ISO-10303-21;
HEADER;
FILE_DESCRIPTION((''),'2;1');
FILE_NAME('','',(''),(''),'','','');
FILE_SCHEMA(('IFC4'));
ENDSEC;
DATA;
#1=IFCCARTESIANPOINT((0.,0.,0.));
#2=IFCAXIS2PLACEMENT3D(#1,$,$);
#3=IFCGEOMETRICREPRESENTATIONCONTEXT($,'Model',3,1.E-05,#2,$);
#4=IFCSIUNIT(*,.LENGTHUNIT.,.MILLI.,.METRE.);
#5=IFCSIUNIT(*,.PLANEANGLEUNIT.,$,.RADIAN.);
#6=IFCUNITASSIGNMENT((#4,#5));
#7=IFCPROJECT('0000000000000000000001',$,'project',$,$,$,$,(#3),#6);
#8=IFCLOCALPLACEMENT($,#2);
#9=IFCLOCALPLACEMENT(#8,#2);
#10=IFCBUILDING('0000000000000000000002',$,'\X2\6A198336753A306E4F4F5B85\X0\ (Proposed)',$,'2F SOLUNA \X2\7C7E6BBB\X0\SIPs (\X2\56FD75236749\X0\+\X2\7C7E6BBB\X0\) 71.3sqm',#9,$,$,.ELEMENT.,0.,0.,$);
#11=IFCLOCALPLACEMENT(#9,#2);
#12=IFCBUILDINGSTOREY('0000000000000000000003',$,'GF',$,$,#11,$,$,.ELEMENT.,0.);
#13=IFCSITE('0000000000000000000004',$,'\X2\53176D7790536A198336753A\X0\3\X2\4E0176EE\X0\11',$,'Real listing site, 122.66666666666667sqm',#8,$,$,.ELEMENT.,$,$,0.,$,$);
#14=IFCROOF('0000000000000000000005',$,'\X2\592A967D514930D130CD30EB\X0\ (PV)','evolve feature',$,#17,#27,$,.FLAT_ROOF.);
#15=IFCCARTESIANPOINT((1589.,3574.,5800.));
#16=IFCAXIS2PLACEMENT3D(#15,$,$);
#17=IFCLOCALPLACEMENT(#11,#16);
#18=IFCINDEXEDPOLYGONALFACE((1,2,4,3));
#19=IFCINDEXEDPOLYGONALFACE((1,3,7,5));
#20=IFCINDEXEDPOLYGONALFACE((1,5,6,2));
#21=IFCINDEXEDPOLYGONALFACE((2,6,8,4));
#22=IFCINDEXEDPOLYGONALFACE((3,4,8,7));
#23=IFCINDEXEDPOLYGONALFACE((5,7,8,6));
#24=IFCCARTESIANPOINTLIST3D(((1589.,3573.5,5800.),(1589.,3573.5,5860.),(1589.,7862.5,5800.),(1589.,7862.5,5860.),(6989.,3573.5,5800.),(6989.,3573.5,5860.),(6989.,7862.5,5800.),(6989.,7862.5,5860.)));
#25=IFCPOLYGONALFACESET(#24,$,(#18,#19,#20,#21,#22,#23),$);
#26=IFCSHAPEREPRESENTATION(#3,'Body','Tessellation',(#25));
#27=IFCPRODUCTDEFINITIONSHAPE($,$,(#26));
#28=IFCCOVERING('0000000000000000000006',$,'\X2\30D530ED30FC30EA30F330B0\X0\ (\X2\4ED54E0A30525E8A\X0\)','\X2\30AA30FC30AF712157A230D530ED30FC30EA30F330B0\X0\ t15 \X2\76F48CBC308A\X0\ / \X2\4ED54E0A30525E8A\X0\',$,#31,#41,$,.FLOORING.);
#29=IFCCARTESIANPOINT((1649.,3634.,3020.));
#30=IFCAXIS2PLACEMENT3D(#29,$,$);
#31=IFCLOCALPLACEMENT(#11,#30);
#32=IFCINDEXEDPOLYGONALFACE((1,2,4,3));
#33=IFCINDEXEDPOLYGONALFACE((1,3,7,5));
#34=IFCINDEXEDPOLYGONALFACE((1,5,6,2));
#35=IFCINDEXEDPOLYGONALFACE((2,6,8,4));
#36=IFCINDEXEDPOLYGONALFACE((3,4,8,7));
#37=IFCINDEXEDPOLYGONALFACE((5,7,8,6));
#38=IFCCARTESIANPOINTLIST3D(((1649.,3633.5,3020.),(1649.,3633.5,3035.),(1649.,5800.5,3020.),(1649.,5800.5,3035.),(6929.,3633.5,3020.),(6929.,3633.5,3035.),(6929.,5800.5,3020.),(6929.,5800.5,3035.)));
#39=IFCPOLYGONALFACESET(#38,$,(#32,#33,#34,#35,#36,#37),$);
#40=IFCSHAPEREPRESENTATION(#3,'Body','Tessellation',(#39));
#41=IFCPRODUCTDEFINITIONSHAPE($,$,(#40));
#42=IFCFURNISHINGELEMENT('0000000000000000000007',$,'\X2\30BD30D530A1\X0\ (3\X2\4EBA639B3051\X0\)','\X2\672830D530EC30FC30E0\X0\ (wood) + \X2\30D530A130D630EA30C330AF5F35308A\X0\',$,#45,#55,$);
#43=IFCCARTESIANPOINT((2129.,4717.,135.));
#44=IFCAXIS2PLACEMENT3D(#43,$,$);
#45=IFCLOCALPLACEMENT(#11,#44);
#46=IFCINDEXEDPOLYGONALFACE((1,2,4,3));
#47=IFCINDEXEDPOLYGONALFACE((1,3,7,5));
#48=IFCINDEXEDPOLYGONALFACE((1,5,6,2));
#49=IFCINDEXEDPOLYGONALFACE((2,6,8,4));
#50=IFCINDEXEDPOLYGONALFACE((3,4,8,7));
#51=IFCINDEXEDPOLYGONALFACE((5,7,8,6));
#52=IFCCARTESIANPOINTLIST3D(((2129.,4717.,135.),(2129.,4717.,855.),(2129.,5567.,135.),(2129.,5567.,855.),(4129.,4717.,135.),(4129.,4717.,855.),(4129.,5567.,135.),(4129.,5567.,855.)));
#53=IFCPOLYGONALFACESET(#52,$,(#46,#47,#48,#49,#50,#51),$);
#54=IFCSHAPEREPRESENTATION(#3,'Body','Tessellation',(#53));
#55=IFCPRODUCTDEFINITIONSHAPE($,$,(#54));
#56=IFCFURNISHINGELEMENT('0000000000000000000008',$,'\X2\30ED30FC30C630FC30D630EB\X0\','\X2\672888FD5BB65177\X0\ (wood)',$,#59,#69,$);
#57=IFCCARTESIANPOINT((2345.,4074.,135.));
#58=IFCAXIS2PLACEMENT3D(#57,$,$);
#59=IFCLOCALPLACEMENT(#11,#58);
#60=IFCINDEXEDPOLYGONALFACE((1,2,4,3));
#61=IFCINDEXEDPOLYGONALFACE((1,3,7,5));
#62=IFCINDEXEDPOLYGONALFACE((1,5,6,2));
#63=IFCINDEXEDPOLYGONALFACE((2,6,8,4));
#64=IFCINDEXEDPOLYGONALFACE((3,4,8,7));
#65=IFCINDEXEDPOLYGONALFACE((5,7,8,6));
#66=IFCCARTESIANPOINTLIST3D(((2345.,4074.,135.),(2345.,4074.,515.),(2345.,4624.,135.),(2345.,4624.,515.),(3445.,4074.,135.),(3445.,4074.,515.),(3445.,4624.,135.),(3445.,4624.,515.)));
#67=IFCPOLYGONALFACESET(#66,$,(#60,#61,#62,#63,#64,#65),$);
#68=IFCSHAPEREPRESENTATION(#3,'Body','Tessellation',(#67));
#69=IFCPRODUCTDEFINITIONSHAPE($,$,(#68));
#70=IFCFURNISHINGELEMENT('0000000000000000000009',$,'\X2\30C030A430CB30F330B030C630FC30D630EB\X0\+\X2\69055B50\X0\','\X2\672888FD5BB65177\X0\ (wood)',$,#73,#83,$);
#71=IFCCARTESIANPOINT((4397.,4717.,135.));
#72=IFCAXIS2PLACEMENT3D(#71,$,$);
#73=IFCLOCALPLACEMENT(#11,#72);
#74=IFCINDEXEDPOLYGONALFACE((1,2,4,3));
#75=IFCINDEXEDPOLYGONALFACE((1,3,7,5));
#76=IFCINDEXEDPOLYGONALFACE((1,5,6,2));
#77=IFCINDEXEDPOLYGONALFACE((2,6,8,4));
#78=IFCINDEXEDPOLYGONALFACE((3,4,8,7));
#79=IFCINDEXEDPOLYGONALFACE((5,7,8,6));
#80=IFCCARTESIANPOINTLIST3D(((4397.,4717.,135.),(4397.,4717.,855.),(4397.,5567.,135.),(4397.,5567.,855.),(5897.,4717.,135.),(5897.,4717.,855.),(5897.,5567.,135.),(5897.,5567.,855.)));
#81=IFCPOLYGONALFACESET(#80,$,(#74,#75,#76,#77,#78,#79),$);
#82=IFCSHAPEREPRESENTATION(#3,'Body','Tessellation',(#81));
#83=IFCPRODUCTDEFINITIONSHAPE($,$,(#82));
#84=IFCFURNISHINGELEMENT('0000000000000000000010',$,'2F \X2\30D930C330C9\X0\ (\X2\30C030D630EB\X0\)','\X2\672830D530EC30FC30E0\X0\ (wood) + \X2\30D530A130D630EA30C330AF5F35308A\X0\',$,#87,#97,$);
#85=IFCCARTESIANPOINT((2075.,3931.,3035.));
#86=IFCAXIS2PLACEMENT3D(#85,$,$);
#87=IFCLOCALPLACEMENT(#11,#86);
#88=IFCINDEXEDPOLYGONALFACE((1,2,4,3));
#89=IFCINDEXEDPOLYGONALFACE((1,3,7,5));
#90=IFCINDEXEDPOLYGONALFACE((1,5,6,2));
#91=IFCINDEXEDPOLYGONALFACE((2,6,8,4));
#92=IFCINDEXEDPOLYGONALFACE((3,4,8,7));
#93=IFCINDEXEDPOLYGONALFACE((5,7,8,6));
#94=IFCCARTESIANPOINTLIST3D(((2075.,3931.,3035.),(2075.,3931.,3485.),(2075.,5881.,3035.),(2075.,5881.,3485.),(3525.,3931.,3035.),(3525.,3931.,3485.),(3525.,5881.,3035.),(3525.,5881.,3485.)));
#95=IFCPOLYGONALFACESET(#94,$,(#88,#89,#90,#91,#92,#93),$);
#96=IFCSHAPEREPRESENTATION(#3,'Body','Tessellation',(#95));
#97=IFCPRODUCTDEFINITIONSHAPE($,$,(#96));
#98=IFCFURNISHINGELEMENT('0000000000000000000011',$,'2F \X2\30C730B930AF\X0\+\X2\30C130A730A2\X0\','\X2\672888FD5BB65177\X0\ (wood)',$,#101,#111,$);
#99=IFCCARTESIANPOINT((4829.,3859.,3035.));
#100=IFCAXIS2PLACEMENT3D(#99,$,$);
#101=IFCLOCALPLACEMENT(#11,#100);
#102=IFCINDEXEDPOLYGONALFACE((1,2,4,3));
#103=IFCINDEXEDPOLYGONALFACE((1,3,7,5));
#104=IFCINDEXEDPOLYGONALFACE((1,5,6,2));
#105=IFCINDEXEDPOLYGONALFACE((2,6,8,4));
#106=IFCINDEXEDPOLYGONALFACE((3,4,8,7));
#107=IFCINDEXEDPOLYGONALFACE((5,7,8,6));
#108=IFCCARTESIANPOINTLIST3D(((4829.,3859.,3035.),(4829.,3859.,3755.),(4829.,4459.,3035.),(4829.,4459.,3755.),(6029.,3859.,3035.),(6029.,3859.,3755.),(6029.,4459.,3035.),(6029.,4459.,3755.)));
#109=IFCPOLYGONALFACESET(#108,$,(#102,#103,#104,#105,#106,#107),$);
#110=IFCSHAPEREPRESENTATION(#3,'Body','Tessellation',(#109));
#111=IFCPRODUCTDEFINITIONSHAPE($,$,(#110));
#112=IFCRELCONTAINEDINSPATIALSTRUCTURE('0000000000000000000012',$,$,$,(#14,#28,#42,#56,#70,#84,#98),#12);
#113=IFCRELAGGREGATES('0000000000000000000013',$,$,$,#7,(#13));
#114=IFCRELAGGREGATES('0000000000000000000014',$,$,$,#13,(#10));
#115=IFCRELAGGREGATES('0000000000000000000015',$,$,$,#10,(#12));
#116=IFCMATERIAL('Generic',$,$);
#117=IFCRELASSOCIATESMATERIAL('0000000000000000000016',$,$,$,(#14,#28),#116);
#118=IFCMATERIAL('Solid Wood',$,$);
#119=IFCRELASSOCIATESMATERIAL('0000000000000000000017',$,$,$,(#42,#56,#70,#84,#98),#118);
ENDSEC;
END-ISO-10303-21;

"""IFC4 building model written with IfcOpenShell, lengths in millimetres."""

from ifc_helpers import new_model, si_unit, frame, frame_2d, origin, place, context, project, spatial, rectangle, extrude, material, element, save


model = new_model("IFC4")

# Units and contexts
model_context = context("Model", 3, precision=1e-05, world=origin())
ifc_project = project(units=[si_unit("LENGTHUNIT", "METRE", prefix="MILLI"), si_unit("PLANEANGLEUNIT", "RADIAN")], contexts=[model_context])

# Site, building, storey
site_placement = place(None, origin())
site = spatial("IfcSite", under=ifc_project, at=site_placement, Name="北海道標茶町3丁目11", ObjectType="Real listing site, 122.66666666666667sqm", CompositionType="ELEMENT", RefElevation=0.0)
building_placement = place(site_placement, origin())
building = spatial("IfcBuilding", under=site, at=building_placement, Name="標茶町の住宅 (Proposed)", ObjectType="2F SOLUNA 籾殻SIPs (国産杉+籾殻) 71.3sqm", CompositionType="ELEMENT", ElevationOfRefHeight=0.0, ElevationOfTerrain=0.0)
storey_placement = place(building_placement, origin())
storey = spatial("IfcBuildingStorey", under=building, at=storey_placement, Name="GF", CompositionType="ELEMENT", Elevation=0.0)

# Shared definitions
ifc_material_1 = material(Name="Solid Wood")

# Shared definitions
ifc_material_2 = material(Name="Generic")

# Roof
roof_1_placement = place(storey_placement, frame((1589.0, 3574.0, 5800.0)))
element("IfcRoof", 1, at=roof_1_placement, inside=storey, material=ifc_material_2, Name="太陽光パネル (PV)", Description="evolve feature", PredefinedType="FLAT_ROOF", context=model_context, shape_type="SweptSolid", body=[
    extrude(rectangle(XDim=5400.0, YDim=4289.0, at=frame_2d((2700.0, 2144.0))), frame((1589.0, 3574.0, 5800.0)), (0.0, 0.0, 1.0), 60.0),
])

# Covering
covering_placement = place(storey_placement, frame((1649.0, 3634.0, 3020.0)))
element("IfcCovering", 2, at=covering_placement, inside=storey, material=ifc_material_2, Name="フローリング (仕上げ床)", Description="オーク無垢フローリング t15 直貼り / 仕上げ床", PredefinedType="FLOORING", context=model_context, shape_type="SweptSolid", body=[
    extrude(rectangle(XDim=5280.0, YDim=2167.0, at=frame_2d((2640.0, 1083.0))), frame((1649.0, 3634.0, 3020.0)), (0.0, 0.0, 1.0), 15.0),
])

# Furnishing elements
furnishing_1_placement = place(storey_placement, frame((2129.0, 4717.0, 135.0)))
element("IfcFurnishingElement", 3, at=furnishing_1_placement, inside=storey, material=ifc_material_1, Name="ソファ (3人掛け)", Description="木フレーム (wood) + ファブリック張り", context=model_context, shape_type="SweptSolid", body=[
    extrude(rectangle(XDim=2000.0, YDim=850.0, at=frame_2d((1000.0, 425.0))), frame((2129.0, 4717.0, 135.0)), (0.0, 0.0, 1.0), 720.0),
])
furnishing_2_placement = place(storey_placement, frame((2345.0, 4074.0, 135.0)))
element("IfcFurnishingElement", 4, at=furnishing_2_placement, inside=storey, material=ifc_material_1, Name="ローテーブル", Description="木製家具 (wood)", context=model_context, shape_type="SweptSolid", body=[
    extrude(rectangle(XDim=1100.0, YDim=550.0, at=frame_2d((550.0, 275.0))), frame((2345.0, 4074.0, 135.0)), (0.0, 0.0, 1.0), 380.0),
])
furnishing_3_placement = place(storey_placement, frame((4397.0, 4717.0, 135.0)))
element("IfcFurnishingElement", 5, at=furnishing_3_placement, inside=storey, material=ifc_material_1, Name="ダイニングテーブル+椅子", Description="木製家具 (wood)", context=model_context, shape_type="SweptSolid", body=[
    extrude(rectangle(XDim=1500.0, YDim=850.0, at=frame_2d((750.0, 425.0))), frame((4397.0, 4717.0, 135.0)), (0.0, 0.0, 1.0), 720.0),
])
furnishing_4_placement = place(storey_placement, frame((2075.0, 3931.0, 3035.0)))
element("IfcFurnishingElement", 6, at=furnishing_4_placement, inside=storey, material=ifc_material_1, Name="2F ベッド (ダブル)", Description="木フレーム (wood) + ファブリック張り", context=model_context, shape_type="SweptSolid", body=[
    extrude(rectangle(XDim=1450.0, YDim=1950.0, at=frame_2d((725.0, 975.0))), frame((2075.0, 3931.0, 3035.0)), (0.0, 0.0, 1.0), 450.0),
])
furnishing_5_placement = place(storey_placement, frame((4829.0, 3859.0, 3035.0)))
element("IfcFurnishingElement", 7, at=furnishing_5_placement, inside=storey, material=ifc_material_1, Name="2F デスク+チェア", Description="木製家具 (wood)", context=model_context, shape_type="SweptSolid", body=[
    extrude(rectangle(XDim=1200.0, YDim=600.0, at=frame_2d((600.0, 300.0))), frame((4829.0, 3859.0, 3035.0)), (0.0, 0.0, 1.0), 720.0),
])

save(model, "model.ifc")
